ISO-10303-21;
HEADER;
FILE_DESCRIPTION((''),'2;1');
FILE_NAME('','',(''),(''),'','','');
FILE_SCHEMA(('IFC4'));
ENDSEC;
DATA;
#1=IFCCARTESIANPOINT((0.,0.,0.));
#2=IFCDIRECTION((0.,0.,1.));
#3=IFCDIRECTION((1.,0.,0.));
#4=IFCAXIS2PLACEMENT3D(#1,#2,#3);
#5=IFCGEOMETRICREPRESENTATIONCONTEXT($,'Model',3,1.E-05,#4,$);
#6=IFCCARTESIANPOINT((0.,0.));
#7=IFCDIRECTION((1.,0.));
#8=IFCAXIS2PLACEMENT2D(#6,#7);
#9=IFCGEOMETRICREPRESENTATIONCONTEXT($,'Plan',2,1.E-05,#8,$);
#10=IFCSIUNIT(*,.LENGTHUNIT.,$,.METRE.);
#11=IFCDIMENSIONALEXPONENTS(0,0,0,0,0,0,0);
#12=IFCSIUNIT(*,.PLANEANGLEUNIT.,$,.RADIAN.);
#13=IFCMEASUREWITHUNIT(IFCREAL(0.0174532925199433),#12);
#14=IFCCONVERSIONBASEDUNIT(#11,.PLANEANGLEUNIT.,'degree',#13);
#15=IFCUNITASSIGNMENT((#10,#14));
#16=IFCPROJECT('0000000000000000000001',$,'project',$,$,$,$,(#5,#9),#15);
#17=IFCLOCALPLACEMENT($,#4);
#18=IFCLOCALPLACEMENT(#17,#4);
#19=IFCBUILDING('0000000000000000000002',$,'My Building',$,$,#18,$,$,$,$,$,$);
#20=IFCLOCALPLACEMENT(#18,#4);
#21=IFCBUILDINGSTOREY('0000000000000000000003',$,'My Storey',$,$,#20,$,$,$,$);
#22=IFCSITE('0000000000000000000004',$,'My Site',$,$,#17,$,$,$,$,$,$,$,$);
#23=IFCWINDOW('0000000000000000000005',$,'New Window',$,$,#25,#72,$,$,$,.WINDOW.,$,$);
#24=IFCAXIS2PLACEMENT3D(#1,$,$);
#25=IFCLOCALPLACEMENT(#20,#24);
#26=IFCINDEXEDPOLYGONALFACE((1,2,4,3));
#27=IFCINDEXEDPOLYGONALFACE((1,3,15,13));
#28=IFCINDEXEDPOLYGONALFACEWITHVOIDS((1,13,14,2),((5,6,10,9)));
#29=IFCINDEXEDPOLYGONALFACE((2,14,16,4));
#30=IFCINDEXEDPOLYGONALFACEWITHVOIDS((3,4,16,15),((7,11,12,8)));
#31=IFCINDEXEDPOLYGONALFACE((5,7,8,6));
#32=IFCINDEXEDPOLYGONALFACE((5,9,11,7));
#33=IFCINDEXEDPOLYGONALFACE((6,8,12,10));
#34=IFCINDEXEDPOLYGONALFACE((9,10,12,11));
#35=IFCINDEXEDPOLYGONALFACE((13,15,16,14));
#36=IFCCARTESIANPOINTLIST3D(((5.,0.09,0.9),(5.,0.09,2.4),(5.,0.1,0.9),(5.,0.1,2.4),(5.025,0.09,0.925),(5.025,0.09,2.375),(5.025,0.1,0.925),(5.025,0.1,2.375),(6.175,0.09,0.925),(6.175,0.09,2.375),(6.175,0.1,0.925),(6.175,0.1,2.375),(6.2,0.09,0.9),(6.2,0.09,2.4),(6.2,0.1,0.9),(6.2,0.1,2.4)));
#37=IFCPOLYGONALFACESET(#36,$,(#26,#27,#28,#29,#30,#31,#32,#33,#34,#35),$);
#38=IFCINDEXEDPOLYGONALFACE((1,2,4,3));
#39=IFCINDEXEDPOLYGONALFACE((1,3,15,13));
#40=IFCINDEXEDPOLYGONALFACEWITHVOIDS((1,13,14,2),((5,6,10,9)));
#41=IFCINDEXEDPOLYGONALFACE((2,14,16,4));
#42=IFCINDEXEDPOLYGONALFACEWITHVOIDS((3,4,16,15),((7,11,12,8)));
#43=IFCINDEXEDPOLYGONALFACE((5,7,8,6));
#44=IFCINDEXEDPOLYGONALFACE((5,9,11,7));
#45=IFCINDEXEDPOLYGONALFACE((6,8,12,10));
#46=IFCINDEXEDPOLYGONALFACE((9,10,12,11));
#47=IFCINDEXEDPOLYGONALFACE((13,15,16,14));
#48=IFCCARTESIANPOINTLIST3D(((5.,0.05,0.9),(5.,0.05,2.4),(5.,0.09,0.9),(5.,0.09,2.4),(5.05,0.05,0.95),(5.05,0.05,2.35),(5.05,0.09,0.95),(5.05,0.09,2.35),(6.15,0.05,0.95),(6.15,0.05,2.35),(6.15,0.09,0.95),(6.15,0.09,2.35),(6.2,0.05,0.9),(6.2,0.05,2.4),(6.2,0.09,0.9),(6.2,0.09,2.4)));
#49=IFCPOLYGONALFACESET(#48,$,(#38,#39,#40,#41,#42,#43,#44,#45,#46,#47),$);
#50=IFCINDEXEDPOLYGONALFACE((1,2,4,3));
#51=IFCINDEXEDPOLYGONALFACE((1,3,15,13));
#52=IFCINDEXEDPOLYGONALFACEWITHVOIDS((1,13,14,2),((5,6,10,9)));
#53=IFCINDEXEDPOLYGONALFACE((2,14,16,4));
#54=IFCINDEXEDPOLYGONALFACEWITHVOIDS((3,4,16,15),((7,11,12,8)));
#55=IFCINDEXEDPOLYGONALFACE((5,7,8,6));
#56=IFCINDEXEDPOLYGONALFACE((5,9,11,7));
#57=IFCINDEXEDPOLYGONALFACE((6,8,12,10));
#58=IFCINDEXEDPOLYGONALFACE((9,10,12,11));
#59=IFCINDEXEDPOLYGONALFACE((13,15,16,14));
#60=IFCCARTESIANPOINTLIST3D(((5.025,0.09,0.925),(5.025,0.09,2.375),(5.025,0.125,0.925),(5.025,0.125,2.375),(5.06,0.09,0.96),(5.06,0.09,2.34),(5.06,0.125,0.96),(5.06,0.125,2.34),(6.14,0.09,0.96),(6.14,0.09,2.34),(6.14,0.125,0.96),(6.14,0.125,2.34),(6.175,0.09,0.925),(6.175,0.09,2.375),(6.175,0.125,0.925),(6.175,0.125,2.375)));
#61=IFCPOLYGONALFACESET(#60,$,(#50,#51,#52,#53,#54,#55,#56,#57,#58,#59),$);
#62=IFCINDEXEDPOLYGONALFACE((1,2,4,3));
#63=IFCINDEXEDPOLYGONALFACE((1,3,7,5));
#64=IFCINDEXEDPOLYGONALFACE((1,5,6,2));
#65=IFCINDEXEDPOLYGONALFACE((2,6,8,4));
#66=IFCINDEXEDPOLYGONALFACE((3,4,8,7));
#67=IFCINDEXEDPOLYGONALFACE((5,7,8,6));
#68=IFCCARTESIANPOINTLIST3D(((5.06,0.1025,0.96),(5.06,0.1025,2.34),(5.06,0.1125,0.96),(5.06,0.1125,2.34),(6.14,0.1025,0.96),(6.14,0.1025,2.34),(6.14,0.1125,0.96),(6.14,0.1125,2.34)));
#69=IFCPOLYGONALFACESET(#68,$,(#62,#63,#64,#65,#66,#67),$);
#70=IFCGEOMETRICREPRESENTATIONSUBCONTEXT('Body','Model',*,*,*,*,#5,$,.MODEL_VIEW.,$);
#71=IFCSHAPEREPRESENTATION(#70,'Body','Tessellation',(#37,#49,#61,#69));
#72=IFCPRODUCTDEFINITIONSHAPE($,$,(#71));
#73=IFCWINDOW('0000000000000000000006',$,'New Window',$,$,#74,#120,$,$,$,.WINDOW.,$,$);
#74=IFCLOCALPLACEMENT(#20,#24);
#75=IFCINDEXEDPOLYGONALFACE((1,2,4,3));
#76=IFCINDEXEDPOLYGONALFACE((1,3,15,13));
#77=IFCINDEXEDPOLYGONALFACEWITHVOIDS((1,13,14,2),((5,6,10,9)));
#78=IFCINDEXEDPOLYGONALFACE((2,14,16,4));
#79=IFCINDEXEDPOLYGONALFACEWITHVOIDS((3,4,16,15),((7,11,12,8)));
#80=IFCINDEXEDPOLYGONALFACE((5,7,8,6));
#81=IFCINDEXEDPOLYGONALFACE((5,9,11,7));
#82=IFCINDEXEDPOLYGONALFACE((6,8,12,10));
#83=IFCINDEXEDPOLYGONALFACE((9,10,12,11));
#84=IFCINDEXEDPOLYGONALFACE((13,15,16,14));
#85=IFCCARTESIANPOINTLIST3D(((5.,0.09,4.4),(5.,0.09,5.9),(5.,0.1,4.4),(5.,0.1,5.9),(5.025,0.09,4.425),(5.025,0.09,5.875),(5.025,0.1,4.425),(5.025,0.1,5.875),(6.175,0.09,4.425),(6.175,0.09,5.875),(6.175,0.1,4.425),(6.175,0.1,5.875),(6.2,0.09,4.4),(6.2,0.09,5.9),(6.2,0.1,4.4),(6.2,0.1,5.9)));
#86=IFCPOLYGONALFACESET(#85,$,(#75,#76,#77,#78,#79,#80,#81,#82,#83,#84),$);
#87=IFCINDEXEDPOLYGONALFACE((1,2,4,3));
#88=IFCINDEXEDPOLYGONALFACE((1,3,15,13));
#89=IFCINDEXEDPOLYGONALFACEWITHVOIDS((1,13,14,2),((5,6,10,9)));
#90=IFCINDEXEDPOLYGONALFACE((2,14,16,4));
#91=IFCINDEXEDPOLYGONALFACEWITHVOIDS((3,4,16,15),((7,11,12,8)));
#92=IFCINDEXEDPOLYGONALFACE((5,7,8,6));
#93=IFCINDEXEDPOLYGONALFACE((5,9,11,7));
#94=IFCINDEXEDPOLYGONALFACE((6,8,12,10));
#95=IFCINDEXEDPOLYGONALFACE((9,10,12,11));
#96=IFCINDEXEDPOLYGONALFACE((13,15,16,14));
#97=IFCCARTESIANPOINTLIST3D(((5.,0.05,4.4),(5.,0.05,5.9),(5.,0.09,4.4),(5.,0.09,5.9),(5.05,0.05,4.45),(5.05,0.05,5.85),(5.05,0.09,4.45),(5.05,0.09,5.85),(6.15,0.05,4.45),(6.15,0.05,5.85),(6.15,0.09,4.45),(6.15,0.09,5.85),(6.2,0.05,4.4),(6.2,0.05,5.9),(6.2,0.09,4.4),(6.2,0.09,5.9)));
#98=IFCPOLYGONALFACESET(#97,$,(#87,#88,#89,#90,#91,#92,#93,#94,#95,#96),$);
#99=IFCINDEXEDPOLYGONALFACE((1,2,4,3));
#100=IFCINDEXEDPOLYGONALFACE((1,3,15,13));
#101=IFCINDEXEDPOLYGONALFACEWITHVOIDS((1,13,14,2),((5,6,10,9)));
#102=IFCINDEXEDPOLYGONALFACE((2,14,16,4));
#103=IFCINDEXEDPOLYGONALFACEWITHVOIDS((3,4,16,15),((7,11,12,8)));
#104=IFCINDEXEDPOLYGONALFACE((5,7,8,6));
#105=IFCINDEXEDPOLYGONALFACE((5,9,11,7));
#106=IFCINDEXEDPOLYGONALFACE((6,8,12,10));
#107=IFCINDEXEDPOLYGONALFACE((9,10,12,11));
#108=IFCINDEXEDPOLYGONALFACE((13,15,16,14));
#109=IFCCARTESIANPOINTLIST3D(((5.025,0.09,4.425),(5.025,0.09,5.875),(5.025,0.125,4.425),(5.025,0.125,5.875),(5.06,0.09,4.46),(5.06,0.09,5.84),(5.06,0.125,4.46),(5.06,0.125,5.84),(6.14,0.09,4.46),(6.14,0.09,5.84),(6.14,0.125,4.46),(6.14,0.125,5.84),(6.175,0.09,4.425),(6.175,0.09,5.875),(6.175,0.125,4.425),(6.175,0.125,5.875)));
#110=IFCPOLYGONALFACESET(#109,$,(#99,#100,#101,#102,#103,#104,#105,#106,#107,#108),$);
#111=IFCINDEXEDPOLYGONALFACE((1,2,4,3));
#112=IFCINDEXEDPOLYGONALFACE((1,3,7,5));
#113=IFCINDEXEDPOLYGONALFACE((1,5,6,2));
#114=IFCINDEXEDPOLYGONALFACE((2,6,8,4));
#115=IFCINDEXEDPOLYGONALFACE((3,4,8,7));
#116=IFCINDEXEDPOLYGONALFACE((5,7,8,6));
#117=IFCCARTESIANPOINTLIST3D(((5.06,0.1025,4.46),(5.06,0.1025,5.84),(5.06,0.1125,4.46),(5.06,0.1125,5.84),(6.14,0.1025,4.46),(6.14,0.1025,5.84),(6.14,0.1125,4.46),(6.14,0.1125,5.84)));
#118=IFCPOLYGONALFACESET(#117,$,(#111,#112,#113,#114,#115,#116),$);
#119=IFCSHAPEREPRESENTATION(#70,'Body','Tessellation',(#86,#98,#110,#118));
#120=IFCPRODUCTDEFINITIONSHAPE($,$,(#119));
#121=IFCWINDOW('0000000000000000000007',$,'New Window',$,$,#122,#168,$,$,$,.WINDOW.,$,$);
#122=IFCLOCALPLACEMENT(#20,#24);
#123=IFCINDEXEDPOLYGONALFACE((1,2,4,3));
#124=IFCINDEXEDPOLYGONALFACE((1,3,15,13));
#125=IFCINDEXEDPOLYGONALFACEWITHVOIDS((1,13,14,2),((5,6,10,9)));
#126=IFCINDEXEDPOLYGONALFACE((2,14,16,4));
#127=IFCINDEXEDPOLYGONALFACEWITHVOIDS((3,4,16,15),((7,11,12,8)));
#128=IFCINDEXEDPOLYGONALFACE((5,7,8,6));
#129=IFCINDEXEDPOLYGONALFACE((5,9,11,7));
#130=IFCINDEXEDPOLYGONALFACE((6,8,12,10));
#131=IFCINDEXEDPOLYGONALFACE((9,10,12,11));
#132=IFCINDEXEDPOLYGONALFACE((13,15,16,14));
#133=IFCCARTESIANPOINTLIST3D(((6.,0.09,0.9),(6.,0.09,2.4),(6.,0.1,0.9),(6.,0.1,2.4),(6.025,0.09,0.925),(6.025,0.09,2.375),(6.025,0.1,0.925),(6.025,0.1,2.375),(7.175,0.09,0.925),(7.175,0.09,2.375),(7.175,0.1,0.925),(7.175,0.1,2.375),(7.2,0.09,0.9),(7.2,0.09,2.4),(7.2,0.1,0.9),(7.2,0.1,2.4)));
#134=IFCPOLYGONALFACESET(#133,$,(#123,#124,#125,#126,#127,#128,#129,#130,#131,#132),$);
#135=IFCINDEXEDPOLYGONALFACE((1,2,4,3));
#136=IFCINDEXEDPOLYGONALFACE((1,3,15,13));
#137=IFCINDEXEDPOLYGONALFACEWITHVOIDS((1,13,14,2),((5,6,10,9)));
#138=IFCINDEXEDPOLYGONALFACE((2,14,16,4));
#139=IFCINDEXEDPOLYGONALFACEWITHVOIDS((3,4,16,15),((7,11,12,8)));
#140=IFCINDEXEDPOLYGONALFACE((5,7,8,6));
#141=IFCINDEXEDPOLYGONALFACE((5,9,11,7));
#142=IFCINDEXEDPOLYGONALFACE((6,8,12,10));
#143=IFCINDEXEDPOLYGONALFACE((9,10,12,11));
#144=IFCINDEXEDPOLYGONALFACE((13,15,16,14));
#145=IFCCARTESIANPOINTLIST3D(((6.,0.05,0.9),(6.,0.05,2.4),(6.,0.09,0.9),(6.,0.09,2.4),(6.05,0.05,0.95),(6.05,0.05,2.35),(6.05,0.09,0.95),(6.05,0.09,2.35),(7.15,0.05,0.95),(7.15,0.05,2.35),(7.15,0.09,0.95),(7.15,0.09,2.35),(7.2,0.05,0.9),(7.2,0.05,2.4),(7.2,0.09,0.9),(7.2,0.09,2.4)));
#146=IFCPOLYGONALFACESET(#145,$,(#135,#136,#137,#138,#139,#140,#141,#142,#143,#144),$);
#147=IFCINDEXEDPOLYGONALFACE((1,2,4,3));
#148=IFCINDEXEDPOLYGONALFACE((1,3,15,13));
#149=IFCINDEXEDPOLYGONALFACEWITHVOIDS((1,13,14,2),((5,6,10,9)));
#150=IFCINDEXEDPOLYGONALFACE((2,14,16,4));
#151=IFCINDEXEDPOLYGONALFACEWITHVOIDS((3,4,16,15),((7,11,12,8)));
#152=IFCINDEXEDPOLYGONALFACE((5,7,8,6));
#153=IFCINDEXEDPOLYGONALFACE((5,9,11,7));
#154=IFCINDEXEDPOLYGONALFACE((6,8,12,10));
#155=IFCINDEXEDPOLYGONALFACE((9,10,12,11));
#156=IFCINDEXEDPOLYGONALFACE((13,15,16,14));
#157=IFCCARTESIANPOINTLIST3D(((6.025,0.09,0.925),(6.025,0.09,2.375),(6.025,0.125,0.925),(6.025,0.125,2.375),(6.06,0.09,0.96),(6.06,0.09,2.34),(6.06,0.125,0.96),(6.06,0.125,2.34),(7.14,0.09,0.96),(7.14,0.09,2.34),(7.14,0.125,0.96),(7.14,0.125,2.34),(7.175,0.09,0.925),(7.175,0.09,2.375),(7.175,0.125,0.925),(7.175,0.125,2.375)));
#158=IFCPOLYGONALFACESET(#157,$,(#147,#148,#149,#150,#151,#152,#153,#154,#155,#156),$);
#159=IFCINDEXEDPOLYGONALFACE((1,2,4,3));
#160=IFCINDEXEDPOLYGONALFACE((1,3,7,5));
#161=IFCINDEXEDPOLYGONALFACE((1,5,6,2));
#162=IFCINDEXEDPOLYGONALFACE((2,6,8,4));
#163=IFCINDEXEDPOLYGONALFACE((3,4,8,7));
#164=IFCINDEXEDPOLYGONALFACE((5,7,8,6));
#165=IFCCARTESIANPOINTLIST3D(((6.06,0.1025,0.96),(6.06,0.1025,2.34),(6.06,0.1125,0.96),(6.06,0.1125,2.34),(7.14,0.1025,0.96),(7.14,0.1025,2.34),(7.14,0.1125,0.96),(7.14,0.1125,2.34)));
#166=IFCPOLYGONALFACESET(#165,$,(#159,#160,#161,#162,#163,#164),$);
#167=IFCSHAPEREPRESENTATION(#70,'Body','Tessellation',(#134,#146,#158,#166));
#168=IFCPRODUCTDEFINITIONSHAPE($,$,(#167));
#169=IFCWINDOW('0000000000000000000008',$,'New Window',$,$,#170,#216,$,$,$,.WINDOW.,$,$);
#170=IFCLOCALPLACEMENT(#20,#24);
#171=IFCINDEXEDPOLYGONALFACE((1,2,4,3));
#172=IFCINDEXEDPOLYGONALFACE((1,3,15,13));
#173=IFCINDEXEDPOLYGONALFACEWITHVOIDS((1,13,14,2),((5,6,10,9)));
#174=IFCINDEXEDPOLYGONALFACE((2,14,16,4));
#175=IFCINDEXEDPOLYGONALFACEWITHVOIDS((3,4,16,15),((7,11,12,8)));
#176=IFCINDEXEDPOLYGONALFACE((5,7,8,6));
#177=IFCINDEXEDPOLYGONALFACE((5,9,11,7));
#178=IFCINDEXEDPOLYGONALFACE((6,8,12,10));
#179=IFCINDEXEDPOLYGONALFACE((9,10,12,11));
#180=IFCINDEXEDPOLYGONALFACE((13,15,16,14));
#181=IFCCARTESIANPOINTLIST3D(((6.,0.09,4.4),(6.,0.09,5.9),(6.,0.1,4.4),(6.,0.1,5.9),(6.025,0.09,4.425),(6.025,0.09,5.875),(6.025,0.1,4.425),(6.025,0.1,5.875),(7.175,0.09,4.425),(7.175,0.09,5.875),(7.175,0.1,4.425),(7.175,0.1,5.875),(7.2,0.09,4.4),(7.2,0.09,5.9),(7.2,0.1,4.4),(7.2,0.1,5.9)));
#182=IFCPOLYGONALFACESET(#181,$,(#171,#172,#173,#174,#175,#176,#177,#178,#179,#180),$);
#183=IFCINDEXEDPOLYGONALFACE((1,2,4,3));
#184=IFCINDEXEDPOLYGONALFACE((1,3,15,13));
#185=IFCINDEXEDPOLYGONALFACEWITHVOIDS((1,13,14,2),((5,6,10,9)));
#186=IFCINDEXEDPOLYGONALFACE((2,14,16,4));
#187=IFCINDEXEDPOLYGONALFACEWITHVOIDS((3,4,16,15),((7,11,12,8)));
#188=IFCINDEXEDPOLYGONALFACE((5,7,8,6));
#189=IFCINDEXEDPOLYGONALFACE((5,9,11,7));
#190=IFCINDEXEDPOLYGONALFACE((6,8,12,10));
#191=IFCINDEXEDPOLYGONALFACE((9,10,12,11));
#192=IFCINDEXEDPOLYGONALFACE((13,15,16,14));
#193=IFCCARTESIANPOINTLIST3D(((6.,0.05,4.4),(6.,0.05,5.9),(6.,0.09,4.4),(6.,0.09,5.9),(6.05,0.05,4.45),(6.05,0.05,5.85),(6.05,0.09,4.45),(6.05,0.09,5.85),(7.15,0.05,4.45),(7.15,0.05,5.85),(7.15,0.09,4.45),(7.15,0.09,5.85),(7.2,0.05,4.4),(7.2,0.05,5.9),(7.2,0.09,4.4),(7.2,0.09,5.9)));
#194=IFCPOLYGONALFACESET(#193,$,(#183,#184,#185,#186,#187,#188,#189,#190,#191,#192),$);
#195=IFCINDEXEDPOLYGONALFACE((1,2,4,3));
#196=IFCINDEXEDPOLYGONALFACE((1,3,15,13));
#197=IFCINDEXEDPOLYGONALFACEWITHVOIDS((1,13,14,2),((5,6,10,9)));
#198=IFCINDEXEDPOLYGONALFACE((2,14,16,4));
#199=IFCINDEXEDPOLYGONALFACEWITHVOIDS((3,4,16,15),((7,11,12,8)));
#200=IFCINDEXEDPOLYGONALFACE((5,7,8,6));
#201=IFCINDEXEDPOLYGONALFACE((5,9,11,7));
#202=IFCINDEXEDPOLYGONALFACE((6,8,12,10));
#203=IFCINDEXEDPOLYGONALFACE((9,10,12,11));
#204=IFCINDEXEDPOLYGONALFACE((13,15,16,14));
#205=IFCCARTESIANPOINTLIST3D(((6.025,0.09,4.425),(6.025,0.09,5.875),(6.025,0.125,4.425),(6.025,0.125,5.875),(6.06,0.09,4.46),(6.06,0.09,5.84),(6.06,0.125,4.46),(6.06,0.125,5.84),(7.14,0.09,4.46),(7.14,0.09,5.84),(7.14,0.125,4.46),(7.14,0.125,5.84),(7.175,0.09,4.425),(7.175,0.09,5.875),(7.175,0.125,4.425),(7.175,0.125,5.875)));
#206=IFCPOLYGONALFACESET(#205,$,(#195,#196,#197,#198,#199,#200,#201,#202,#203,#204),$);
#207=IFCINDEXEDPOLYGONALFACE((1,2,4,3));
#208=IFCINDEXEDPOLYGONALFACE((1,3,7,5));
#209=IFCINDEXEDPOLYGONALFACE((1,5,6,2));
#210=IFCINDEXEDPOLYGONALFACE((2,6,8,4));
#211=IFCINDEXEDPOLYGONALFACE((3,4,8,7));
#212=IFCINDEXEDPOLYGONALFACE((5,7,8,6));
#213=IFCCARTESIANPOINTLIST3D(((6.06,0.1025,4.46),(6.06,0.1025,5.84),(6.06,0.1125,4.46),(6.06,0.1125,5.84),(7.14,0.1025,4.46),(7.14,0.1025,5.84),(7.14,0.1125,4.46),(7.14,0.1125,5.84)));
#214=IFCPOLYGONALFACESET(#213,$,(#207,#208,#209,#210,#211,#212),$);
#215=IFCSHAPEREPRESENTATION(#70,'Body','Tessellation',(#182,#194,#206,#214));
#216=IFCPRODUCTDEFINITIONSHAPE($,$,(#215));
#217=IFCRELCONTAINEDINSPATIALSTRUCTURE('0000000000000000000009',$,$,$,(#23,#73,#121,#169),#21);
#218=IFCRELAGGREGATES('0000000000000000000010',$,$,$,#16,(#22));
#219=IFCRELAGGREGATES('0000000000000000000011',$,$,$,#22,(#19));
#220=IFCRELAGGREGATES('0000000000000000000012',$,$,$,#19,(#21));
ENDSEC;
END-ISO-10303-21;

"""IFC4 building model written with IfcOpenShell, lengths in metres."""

from ifc_helpers import new_model, entity, si_unit, converted_unit, frame, origin_with_axes, origin_2d_with_axis, place, context, subcontext, project, spatial, line, indexed_curve, outline, extrude, element, save


model = new_model("IFC4")

# Units and contexts
model_context = context("Model", 3, precision=1e-05, world=origin_with_axes())
plan_context = context("Plan", 2, precision=1e-05, world=origin_2d_with_axis())
body_context = subcontext(model_context, "Body", "Model", "MODEL_VIEW")
ifc_project = project(units=[si_unit("LENGTHUNIT", "METRE"), converted_unit("PLANEANGLEUNIT", "degree", entity("IfcReal", 0.0174532925199433), si_unit("PLANEANGLEUNIT", "RADIAN"), dimensions=[0, 0, 0, 0, 0, 0, 0])], contexts=[model_context, plan_context])

# Site, building, storey
site_placement = place(None, origin_with_axes())
site = spatial("IfcSite", under=ifc_project, at=site_placement, Name="My Site")
building_placement = place(site_placement, origin_with_axes())
building = spatial("IfcBuilding", under=site, at=building_placement, Name="My Building")
storey_placement = place(building_placement, origin_with_axes())
storey = spatial("IfcBuildingStorey", under=building, at=storey_placement, Name="My Storey")

# Windows
for number, where, z_axis, x_axis, name in (
    (1, (5.0, 0.0, 0.9), (0.0, 0.0, 1.0), (1.0, 0.0, 0.0), "New Window"),
    (2, (5.0, 0.0, 4.4), (0.0, 0.0, 1.0), (1.0, 0.0, 0.0), "New Window"),
):
    element("IfcWindow", number, at=place(storey_placement, frame(where, z_axis=z_axis, x_axis=x_axis)), inside=storey, Name=name, PredefinedType="WINDOW", context=body_context, shape_type="SweptSolid", body=[
        extrude(outline(indexed_curve([(0.0, 0.0), (1.2, 0.0), (1.2, 1.5), (0.0, 1.5)], segments=[line(1, 2, 3, 4, 1)]), holes=[indexed_curve([(0.025, 0.025), (1.175, 0.025), (1.175, 1.475), (0.025, 1.475)], segments=[line(1, 2, 3, 4, 1)])]), frame((0.0, 0.09, 0.0), z_axis=(0.0, -1.0, 0.0), x_axis=(1.0, 0.0, 0.0)), (0.0, 0.0, -1.0), 0.01),
        extrude(outline(indexed_curve([(0.0, 0.0), (1.2, 0.0), (1.2, 1.5), (0.0, 1.5)], segments=[line(1, 2, 3, 4, 1)]), holes=[indexed_curve([(0.05, 0.05), (1.15, 0.05), (1.15, 1.45), (0.05, 1.45)], segments=[line(1, 2, 3, 4, 1)])]), frame((0.0, 0.05, 0.0), z_axis=(0.0, -1.0, 0.0), x_axis=(1.0, 0.0, 0.0)), (0.0, 0.0, -1.0), 0.04),
        extrude(outline(indexed_curve([(0.0, 0.0), (1.15, 0.0), (1.15, 1.45), (0.0, 1.45)], segments=[line(1, 2, 3, 4, 1)]), holes=[indexed_curve([(0.035, 0.035), (1.115, 0.035), (1.115, 1.415), (0.035, 1.415)], segments=[line(1, 2, 3, 4, 1)])]), frame((0.025, 0.09, 0.025), z_axis=(0.0, -1.0, 0.0), x_axis=(1.0, 0.0, 0.0)), (0.0, 0.0, -1.0), 0.035),
        extrude(outline(indexed_curve([(0.035, 0.035), (1.115, 0.035), (1.115, 1.415), (0.035, 1.415)], segments=[line(1, 2, 3, 4, 1)])), frame((0.025, 0.1025, 0.025), z_axis=(0.0, -1.0, 0.0), x_axis=(1.0, 0.0, 0.0)), (0.0, 0.0, -1.0), 0.01),
    ])

# Windows
for number, where, z_axis, x_axis, name in (
    (3, (6.0, 0.0, 0.9), (0.0, 0.0, 1.0), (1.0, 0.0, 0.0), "New Window"),
    (4, (6.0, 0.0, 4.4), (0.0, 0.0, 1.0), (1.0, 0.0, 0.0), "New Window"),
):
    element("IfcWindow", number, at=place(storey_placement, frame(where, z_axis=z_axis, x_axis=x_axis)), inside=storey, Name=name, PredefinedType="WINDOW", context=body_context, shape_type="SweptSolid", body=[
        extrude(outline(indexed_curve([(0.0, 0.0), (1.2, 0.0), (1.2, 1.5), (0.0, 1.5)], segments=[line(1, 2, 3, 4, 1)]), holes=[indexed_curve([(0.025, 0.025), (1.175, 0.025), (1.175, 1.475), (0.025, 1.475)], segments=[line(1, 2, 3, 4, 1)])]), frame((0.0, 0.09, 0.0), z_axis=(0.0, -1.0, 0.0), x_axis=(1.0, 0.0, 0.0)), (0.0, 0.0, -1.0), 0.01),
        extrude(outline(indexed_curve([(0.0, 0.0), (1.2, 0.0), (1.2, 1.5), (0.0, 1.5)], segments=[line(1, 2, 3, 4, 1)]), holes=[indexed_curve([(0.05, 0.05), (1.15, 0.05), (1.15, 1.45), (0.05, 1.45)], segments=[line(1, 2, 3, 4, 1)])]), frame((0.0, 0.05, 0.0), z_axis=(0.0, -1.0, 0.0), x_axis=(1.0, 0.0, 0.0)), (0.0, 0.0, -1.0), 0.04),
        extrude(outline(indexed_curve([(0.0, 0.0), (1.15, 0.0), (1.15, 1.45), (0.0, 1.45)], segments=[line(1, 2, 3, 4, 1)]), holes=[indexed_curve([(0.035, 0.035), (1.115, 0.035), (1.115, 1.415), (0.035, 1.415)], segments=[line(1, 2, 3, 4, 1)])]), frame((0.025, 0.09, 0.025), z_axis=(0.0, -1.0, 0.0), x_axis=(1.0, 0.0, 0.0)), (0.0, 0.0, -1.0), 0.035),
        extrude(outline(indexed_curve([(0.035, 0.035), (1.115, 0.035), (1.115, 1.415), (0.035, 1.415)], segments=[line(1, 2, 3, 4, 1)])), frame((0.025, 0.1025, 0.025), z_axis=(0.0, -1.0, 0.0), x_axis=(1.0, 0.0, 0.0)), (0.0, 0.0, -1.0), 0.01),
    ])

save(model, "model.ifc")
